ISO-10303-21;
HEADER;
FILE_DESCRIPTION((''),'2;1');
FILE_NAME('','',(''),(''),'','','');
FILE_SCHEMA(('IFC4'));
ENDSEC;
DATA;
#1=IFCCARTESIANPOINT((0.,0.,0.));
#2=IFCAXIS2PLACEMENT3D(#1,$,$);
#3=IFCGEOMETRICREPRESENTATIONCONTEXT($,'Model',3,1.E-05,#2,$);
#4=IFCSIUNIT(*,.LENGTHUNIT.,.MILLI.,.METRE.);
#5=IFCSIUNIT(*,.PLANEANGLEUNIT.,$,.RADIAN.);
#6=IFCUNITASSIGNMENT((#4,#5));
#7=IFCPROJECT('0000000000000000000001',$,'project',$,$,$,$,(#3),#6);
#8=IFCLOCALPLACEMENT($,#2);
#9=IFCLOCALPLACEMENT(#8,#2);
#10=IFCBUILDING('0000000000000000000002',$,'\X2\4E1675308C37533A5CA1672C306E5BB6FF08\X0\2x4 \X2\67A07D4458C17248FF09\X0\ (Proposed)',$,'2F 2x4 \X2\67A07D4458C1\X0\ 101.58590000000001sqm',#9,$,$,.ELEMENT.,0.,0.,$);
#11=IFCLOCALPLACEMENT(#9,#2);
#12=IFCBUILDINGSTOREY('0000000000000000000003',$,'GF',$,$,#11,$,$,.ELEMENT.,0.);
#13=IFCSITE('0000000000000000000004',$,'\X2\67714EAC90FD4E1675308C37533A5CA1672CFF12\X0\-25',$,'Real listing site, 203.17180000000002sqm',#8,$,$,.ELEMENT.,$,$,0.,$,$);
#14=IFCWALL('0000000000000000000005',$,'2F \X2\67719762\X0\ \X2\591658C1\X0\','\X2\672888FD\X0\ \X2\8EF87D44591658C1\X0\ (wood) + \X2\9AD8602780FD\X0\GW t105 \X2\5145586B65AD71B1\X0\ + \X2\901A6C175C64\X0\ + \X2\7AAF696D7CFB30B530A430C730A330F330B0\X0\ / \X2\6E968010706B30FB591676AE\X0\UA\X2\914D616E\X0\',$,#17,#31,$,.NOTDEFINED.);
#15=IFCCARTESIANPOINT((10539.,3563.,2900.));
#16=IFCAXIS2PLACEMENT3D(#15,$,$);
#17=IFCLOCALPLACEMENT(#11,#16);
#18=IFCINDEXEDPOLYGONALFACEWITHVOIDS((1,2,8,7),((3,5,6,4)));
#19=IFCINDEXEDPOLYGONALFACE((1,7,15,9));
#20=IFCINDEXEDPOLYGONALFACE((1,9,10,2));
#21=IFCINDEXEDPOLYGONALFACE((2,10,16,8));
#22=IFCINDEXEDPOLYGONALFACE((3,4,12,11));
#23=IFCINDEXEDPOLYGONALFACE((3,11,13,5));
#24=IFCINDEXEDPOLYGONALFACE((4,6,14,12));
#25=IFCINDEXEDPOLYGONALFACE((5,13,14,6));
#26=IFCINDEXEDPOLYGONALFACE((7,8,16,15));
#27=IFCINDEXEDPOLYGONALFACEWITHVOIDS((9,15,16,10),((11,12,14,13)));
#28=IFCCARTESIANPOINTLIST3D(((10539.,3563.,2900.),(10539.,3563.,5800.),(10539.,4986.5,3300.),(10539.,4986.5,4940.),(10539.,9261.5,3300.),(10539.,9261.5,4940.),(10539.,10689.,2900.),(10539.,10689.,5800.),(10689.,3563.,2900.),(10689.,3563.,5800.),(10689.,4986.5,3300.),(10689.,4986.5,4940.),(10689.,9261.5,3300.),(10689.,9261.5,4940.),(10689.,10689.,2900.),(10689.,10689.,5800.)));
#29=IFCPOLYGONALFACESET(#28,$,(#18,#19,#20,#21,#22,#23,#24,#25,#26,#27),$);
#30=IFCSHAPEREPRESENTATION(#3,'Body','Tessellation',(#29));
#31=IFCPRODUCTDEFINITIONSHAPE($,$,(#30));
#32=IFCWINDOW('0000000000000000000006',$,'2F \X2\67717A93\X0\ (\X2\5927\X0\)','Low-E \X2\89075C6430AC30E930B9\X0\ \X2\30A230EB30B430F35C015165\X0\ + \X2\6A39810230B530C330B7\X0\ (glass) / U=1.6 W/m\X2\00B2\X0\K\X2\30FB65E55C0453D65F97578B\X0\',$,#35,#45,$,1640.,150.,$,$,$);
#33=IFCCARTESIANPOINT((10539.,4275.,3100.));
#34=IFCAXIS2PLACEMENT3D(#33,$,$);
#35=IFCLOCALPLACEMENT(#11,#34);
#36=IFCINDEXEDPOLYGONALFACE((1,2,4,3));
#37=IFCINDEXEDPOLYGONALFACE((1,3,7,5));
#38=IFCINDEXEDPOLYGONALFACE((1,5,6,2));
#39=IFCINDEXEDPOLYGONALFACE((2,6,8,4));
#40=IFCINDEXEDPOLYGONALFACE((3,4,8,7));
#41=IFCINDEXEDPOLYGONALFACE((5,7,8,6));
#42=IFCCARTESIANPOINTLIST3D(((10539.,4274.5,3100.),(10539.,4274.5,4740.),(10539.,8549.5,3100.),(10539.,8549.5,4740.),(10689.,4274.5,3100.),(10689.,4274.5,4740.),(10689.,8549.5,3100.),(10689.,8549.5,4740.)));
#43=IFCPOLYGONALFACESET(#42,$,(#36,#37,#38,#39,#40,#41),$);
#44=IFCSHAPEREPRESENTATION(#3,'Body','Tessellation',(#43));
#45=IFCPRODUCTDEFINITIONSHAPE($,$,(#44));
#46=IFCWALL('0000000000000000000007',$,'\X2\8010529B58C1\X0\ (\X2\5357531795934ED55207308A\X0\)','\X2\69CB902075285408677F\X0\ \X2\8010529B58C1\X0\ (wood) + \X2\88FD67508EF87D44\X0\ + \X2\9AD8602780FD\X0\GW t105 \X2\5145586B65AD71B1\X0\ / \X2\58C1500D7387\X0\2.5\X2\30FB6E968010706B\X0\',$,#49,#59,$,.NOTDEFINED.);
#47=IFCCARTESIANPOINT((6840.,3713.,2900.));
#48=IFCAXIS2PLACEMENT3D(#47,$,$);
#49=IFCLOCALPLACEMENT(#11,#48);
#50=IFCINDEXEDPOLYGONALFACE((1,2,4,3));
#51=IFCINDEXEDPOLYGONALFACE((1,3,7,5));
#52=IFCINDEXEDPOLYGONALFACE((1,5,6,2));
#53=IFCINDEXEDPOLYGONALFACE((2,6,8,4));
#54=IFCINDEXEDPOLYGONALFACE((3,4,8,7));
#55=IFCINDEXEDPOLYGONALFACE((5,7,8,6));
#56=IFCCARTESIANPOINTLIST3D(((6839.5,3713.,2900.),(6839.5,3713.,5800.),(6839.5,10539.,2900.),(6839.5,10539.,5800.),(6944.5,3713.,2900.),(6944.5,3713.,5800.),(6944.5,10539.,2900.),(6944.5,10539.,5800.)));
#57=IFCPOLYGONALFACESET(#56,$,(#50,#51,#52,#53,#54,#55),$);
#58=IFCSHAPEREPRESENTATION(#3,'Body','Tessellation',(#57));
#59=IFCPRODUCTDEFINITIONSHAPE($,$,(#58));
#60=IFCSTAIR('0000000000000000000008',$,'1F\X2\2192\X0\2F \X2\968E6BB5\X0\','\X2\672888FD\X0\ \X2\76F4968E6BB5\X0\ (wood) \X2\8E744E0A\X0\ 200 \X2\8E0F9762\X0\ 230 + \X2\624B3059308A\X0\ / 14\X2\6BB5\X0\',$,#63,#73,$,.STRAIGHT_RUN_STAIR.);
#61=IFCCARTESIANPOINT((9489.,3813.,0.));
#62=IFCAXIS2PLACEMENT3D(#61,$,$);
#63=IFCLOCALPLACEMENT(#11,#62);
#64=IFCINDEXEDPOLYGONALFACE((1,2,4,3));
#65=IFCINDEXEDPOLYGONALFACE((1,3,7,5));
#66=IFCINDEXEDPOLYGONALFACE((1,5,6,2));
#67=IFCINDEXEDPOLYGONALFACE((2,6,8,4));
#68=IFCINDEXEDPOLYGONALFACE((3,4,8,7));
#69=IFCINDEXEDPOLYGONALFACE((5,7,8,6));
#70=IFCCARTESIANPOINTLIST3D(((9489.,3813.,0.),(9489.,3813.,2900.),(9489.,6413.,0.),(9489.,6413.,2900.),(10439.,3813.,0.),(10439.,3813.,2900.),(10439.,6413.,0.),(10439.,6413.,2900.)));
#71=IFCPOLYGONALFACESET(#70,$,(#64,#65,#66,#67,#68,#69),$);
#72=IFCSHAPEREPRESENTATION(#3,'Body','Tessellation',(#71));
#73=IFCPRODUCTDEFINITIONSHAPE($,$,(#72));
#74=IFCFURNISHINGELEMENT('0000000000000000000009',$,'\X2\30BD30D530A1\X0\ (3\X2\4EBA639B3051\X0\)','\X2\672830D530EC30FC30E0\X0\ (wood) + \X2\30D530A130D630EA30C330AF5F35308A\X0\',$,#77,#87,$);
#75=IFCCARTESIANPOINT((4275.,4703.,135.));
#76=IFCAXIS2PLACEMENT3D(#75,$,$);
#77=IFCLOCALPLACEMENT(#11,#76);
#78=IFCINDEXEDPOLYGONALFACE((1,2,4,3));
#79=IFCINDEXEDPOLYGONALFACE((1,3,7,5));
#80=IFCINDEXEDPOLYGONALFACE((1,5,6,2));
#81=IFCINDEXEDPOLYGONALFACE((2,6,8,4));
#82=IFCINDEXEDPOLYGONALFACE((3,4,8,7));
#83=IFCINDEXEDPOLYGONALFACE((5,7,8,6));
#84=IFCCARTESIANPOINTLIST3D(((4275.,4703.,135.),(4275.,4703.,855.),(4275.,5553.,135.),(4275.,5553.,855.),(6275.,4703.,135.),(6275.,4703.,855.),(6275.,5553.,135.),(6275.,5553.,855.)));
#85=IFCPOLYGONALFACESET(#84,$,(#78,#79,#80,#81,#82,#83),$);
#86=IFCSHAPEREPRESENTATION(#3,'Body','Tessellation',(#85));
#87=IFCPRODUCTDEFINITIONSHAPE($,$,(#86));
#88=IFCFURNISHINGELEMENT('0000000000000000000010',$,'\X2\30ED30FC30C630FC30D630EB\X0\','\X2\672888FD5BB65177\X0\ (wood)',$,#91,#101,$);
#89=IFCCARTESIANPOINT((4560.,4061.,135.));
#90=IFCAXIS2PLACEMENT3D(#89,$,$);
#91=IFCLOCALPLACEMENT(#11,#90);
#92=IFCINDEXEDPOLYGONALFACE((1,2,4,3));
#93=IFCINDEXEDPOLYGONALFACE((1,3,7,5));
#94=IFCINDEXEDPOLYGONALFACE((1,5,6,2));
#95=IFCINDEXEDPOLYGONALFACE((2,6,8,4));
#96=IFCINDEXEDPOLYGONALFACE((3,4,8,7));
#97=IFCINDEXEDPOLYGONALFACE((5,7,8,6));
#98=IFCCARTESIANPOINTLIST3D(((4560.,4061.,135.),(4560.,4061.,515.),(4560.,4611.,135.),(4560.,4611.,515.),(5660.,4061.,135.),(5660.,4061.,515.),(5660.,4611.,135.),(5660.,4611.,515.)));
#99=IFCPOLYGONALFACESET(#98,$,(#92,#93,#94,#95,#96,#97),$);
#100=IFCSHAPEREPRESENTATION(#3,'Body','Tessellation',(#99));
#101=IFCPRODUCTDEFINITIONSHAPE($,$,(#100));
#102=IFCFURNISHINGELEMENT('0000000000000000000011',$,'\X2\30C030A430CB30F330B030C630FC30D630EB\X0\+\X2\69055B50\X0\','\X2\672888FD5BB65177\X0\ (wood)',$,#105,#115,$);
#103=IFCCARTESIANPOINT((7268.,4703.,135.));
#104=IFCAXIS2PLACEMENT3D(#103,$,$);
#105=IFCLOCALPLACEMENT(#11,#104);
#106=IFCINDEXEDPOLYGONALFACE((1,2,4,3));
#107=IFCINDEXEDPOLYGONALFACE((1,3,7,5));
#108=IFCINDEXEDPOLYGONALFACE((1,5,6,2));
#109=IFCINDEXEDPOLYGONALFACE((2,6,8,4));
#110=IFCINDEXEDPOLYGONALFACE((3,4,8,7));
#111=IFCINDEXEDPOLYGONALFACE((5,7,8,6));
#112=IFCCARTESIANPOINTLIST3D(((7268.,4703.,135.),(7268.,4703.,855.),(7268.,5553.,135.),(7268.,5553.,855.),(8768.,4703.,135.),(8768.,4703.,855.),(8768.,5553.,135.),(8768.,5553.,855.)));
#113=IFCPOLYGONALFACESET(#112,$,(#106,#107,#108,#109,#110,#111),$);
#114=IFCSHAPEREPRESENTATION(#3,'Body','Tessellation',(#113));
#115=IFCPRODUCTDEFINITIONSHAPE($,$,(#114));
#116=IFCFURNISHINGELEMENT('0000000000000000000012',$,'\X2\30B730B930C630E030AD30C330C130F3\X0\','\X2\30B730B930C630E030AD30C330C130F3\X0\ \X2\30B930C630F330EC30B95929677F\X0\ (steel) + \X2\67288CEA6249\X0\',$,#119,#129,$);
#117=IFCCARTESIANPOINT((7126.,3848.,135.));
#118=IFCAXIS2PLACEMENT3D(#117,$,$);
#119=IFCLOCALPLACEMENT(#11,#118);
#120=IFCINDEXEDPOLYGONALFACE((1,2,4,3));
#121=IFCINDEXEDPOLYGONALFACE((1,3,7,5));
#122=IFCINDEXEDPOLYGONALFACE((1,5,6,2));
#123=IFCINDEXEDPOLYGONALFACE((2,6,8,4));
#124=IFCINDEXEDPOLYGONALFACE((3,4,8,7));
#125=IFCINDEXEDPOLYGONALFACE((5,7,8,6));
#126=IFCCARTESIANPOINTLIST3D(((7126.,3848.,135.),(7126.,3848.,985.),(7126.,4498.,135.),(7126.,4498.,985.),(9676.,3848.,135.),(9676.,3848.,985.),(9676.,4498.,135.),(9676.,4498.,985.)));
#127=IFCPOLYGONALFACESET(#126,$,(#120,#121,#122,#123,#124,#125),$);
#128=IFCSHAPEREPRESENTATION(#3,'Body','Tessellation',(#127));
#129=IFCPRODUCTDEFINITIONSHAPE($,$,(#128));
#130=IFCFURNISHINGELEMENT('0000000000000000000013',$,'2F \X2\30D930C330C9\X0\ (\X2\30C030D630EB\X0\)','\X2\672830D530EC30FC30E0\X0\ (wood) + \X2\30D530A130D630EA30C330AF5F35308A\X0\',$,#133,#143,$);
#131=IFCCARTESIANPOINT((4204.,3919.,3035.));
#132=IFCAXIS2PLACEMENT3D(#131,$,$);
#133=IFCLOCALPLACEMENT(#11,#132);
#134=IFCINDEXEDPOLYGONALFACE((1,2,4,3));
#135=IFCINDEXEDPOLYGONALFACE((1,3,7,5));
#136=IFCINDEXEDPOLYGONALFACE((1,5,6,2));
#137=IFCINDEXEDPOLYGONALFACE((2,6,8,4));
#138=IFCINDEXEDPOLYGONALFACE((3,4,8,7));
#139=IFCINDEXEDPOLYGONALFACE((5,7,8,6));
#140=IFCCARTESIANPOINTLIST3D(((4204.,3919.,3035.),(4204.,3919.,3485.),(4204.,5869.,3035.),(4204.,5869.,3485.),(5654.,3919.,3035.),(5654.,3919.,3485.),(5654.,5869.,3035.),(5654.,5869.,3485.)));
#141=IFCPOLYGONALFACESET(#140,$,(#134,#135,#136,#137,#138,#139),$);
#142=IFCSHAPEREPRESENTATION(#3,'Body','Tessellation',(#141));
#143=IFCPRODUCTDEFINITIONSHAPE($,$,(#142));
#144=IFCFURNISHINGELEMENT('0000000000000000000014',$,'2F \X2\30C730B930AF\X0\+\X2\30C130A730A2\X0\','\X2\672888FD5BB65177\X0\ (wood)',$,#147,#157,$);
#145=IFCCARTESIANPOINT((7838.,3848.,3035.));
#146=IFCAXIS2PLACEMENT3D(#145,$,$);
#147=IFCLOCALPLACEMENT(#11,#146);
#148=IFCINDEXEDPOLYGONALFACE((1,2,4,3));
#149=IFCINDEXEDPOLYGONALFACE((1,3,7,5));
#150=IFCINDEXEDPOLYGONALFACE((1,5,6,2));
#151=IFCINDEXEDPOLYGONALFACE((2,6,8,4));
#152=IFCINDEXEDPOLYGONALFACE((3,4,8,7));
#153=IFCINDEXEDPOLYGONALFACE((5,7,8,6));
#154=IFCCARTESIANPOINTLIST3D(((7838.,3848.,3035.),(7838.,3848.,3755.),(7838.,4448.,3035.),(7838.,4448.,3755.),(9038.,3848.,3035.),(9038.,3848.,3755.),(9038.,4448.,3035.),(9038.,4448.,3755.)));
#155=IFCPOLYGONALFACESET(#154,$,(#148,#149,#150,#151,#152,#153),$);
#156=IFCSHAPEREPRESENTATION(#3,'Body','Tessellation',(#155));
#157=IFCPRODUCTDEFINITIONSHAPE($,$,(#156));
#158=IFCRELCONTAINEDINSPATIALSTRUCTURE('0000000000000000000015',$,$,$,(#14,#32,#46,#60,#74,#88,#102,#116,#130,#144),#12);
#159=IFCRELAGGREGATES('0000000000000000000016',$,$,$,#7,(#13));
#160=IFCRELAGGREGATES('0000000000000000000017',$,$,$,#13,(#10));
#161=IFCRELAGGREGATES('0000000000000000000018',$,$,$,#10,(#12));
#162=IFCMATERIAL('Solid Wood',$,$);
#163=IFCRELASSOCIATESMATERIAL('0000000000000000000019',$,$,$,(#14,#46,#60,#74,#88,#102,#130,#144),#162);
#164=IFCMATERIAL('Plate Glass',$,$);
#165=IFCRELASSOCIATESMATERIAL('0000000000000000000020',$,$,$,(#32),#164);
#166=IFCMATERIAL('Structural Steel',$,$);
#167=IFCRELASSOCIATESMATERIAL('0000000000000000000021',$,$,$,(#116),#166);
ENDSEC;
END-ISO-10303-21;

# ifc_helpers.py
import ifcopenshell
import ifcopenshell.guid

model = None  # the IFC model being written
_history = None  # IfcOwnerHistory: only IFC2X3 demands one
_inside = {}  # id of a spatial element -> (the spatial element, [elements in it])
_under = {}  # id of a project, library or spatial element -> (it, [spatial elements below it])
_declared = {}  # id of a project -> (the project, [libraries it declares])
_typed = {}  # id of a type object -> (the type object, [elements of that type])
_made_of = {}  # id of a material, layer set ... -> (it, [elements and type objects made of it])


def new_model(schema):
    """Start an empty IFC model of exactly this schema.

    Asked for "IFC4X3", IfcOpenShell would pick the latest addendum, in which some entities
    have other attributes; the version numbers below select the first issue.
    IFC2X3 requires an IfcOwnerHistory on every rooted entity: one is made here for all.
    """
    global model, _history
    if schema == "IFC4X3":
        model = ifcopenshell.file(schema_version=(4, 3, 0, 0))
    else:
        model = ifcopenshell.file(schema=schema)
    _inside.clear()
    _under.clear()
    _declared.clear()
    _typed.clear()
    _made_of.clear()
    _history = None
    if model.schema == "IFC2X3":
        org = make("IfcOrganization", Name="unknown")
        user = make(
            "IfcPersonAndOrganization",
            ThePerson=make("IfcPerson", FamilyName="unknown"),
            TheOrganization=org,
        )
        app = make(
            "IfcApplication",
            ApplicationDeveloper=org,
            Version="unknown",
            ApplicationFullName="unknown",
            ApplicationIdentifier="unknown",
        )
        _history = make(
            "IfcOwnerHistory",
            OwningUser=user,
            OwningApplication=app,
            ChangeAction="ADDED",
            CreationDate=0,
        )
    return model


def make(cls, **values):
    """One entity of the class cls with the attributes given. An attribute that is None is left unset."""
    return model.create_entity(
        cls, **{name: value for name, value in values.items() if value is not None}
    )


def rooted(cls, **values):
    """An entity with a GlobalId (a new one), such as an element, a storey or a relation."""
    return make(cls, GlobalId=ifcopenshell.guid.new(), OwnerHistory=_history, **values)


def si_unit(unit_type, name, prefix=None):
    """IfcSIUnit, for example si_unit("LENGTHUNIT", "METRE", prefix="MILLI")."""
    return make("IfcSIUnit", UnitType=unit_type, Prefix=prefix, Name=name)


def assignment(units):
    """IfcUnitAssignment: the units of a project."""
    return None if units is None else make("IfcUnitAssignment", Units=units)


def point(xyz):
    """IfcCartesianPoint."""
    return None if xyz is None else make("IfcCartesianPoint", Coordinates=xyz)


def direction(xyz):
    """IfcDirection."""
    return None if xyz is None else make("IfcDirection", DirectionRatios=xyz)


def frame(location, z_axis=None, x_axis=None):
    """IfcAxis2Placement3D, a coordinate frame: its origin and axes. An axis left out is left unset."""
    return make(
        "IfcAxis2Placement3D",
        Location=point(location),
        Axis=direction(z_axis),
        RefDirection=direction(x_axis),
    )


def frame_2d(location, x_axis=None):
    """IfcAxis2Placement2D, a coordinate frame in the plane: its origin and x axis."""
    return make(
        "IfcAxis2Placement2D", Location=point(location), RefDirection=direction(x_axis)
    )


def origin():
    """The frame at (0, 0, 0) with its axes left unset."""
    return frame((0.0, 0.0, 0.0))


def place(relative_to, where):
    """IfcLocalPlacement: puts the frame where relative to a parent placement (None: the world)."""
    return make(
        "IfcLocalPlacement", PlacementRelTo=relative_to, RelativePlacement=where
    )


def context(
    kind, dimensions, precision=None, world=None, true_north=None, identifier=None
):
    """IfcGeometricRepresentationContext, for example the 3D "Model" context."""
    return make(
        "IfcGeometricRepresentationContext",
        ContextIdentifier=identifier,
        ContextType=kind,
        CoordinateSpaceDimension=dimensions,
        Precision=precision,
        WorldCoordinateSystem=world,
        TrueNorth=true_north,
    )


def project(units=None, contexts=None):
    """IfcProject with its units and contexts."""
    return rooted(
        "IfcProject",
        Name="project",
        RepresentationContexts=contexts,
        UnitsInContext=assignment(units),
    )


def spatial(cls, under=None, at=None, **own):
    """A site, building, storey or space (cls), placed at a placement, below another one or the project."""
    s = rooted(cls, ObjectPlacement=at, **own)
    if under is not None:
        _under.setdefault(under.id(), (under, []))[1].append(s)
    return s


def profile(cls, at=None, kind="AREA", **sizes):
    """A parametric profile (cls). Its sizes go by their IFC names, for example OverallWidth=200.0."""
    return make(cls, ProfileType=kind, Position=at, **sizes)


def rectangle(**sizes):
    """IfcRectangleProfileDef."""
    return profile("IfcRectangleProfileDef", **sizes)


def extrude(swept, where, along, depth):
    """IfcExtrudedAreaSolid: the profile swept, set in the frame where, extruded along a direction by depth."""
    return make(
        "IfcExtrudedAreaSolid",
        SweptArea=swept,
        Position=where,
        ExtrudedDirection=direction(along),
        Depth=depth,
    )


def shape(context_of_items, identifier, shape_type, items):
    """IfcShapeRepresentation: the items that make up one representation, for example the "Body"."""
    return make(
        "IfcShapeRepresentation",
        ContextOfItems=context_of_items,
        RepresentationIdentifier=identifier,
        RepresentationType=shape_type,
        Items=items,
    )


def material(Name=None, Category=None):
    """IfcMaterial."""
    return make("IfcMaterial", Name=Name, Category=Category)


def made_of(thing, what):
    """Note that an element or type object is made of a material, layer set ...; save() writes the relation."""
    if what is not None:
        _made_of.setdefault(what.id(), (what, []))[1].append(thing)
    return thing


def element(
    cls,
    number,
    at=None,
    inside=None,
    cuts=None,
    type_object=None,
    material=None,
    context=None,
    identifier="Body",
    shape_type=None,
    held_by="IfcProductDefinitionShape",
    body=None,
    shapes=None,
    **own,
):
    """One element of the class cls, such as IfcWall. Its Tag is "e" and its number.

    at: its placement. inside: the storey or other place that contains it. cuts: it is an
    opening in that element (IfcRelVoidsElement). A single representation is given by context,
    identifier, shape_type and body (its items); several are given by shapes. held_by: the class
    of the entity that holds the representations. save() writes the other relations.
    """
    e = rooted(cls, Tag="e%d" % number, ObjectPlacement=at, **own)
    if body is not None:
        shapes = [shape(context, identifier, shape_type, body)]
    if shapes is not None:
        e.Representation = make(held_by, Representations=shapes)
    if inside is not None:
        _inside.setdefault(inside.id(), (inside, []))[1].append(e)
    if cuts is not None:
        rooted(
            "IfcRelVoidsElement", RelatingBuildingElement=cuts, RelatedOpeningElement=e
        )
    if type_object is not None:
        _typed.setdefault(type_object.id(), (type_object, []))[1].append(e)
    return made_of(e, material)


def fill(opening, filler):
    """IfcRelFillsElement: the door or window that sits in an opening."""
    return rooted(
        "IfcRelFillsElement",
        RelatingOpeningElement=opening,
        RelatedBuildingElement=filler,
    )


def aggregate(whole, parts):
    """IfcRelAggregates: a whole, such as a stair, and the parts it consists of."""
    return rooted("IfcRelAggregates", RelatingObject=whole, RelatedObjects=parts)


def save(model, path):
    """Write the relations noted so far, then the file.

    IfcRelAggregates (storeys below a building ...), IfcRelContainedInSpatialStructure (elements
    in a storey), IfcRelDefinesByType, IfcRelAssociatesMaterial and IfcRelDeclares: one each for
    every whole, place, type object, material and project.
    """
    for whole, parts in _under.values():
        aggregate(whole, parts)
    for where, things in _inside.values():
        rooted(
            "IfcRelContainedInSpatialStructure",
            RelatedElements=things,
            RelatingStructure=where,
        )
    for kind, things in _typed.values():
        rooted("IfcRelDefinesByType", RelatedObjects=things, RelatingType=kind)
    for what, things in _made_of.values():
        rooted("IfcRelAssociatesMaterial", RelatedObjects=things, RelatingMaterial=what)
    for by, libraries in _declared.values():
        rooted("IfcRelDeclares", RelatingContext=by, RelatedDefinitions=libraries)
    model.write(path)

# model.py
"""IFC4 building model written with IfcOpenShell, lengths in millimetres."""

from ifc_helpers import new_model, si_unit, frame, frame_2d, origin, place, context, project, spatial, rectangle, extrude, material, element, fill, save


model = new_model("IFC4")

# Units and contexts
model_context = context("Model", 3, precision=1e-05, world=origin())
ifc_project = project(units=[si_unit("LENGTHUNIT", "METRE", prefix="MILLI"), si_unit("PLANEANGLEUNIT", "RADIAN")], contexts=[model_context])

# Site, building, storey
site_placement = place(None, origin())
site = spatial("IfcSite", under=ifc_project, at=site_placement, Name="東京都世田谷区岡本２-25", ObjectType="Real listing site, 203.17180000000002sqm", CompositionType="ELEMENT", RefElevation=0.0)
building_placement = place(site_placement, origin())
building = spatial("IfcBuilding", under=site, at=building_placement, Name="世田谷区岡本の家（2x4 枠組壁版） (Proposed)", ObjectType="2F 2x4 枠組壁 101.58590000000001sqm", CompositionType="ELEMENT", ElevationOfRefHeight=0.0, ElevationOfTerrain=0.0)
storey_placement = place(building_placement, origin())
storey = spatial("IfcBuildingStorey", under=building, at=storey_placement, Name="GF", CompositionType="ELEMENT", Elevation=0.0)

# Shared definitions
ifc_material_1 = material(Name="Solid Wood")
ifc_material_2 = material(Name="Plate Glass")

# Wall, opening, window
wall_1_placement = place(storey_placement, frame((10539.0, 3563.0, 2900.0)))
wall_1 = element("IfcWall", 1, at=wall_1_placement, inside=storey, material=ifc_material_1, Name="2F 東面 外壁", Description="木製 軸組外壁 (wood) + 高性能GW t105 充填断熱 + 通気層 + 窯業系サイディング / 準耐火・外皮UA配慮", PredefinedType="NOTDEFINED", context=model_context, shape_type="SweptSolid", body=[
    extrude(rectangle(XDim=150.0, YDim=7126.0, at=frame_2d((75.0, 3563.0))), frame((10539.0, 3563.0, 2900.0)), (0.0, 0.0, 1.0), 2900.0),
])
opening_1_placement = place(storey_placement, frame((10539.0, 4275.0, 3100.0)))
opening_1 = element("IfcOpeningElement", 2, at=opening_1_placement, cuts=wall_1, PredefinedType="NOTDEFINED", context=model_context, shape_type="SweptSolid", body=[
    extrude(rectangle(XDim=150.0, YDim=4275.0, at=frame_2d((75.0, 2137.0))), frame((10539.0, 4275.0, 3100.0)), (0.0, 0.0, 1.0), 1640.0),
])
window_1_placement = place(storey_placement, frame((10539.0, 4275.0, 3100.0)))
window_1 = element("IfcWindow", 3, at=window_1_placement, inside=storey, material=ifc_material_2, Name="2F 東窓 (大)", Description="Low-E 複層ガラス アルゴン封入 + 樹脂サッシ (glass) / U=1.6 W/m²K・日射取得型", OverallHeight=1640.0, OverallWidth=150.0, context=model_context, shape_type="SweptSolid", body=[
    extrude(rectangle(XDim=150.0, YDim=4275.0, at=frame_2d((75.0, 2137.0))), frame((10539.0, 4275.0, 3100.0)), (0.0, 0.0, 1.0), 1640.0),
])
fill(opening_1, window_1)

# Wall
wall_2_placement = place(storey_placement, frame((6840.0, 3713.0, 2900.0)))
element("IfcWall", 4, at=wall_2_placement, inside=storey, material=ifc_material_1, Name="耐力壁 (南北間仕切り)", Description="構造用合板 耐力壁 (wood) + 製材軸組 + 高性能GW t105 充填断熱 / 壁倍率2.5・準耐火", PredefinedType="NOTDEFINED", context=model_context, shape_type="SweptSolid", body=[
    extrude(rectangle(XDim=105.0, YDim=6826.0, at=frame_2d((52.0, 3413.0))), frame((6840.0, 3713.0, 2900.0)), (0.0, 0.0, 1.0), 2900.0),
])

# Stair
stair_placement = place(storey_placement, frame((9489.0, 3813.0, 0.0)))
element("IfcStair", 5, at=stair_placement, inside=storey, material=ifc_material_1, Name="1F→2F 階段", Description="木製 直階段 (wood) 蹴上 200 踏面 230 + 手すり / 14段", PredefinedType="STRAIGHT_RUN_STAIR", context=model_context, shape_type="SweptSolid", body=[
    extrude(rectangle(XDim=950.0, YDim=2600.0, at=frame_2d((475.0, 1300.0))), frame((9489.0, 3813.0, 0.0)), (0.0, 0.0, 1.0), 2900.0),
])

# Furnishing elements
furnishing_1_placement = place(storey_placement, frame((4275.0, 4703.0, 135.0)))
element("IfcFurnishingElement", 6, at=furnishing_1_placement, inside=storey, material=ifc_material_1, Name="ソファ (3人掛け)", Description="木フレーム (wood) + ファブリック張り", context=model_context, shape_type="SweptSolid", body=[
    extrude(rectangle(XDim=2000.0, YDim=850.0, at=frame_2d((1000.0, 425.0))), frame((4275.0, 4703.0, 135.0)), (0.0, 0.0, 1.0), 720.0),
])
furnishing_2_placement = place(storey_placement, frame((4560.0, 4061.0, 135.0)))
element("IfcFurnishingElement", 7, at=furnishing_2_placement, inside=storey, material=ifc_material_1, Name="ローテーブル", Description="木製家具 (wood)", context=model_context, shape_type="SweptSolid", body=[
    extrude(rectangle(XDim=1100.0, YDim=550.0, at=frame_2d((550.0, 275.0))), frame((4560.0, 4061.0, 135.0)), (0.0, 0.0, 1.0), 380.0),
])
furnishing_3_placement = place(storey_placement, frame((7268.0, 4703.0, 135.0)))
element("IfcFurnishingElement", 8, at=furnishing_3_placement, inside=storey, material=ifc_material_1, Name="ダイニングテーブル+椅子", Description="木製家具 (wood)", context=model_context, shape_type="SweptSolid", body=[
    extrude(rectangle(XDim=1500.0, YDim=850.0, at=frame_2d((750.0, 425.0))), frame((7268.0, 4703.0, 135.0)), (0.0, 0.0, 1.0), 720.0),
])
ifc_material_3 = material(Name="Structural Steel")
furnishing_4_placement = place(storey_placement, frame((7126.0, 3848.0, 135.0)))
element("IfcFurnishingElement", 9, at=furnishing_4_placement, inside=storey, material=ifc_material_3, Name="システムキッチン", Description="システムキッチン ステンレス天板 (steel) + 木質扉", context=model_context, shape_type="SweptSolid", body=[
    extrude(rectangle(XDim=2550.0, YDim=650.0, at=frame_2d((1275.0, 325.0))), frame((7126.0, 3848.0, 135.0)), (0.0, 0.0, 1.0), 850.0),
])
furnishing_5_placement = place(storey_placement, frame((4204.0, 3919.0, 3035.0)))
element("IfcFurnishingElement", 10, at=furnishing_5_placement, inside=storey, material=ifc_material_1, Name="2F ベッド (ダブル)", Description="木フレーム (wood) + ファブリック張り", context=model_context, shape_type="SweptSolid", body=[
    extrude(rectangle(XDim=1450.0, YDim=1950.0, at=frame_2d((725.0, 975.0))), frame((4204.0, 3919.0, 3035.0)), (0.0, 0.0, 1.0), 450.0),
])
furnishing_6_placement = place(storey_placement, frame((7838.0, 3848.0, 3035.0)))
element("IfcFurnishingElement", 11, at=furnishing_6_placement, inside=storey, material=ifc_material_1, Name="2F デスク+チェア", Description="木製家具 (wood)", context=model_context, shape_type="SweptSolid", body=[
    extrude(rectangle(XDim=1200.0, YDim=600.0, at=frame_2d((600.0, 300.0))), frame((7838.0, 3848.0, 3035.0)), (0.0, 0.0, 1.0), 720.0),
])

save(model, "model.ifc")
